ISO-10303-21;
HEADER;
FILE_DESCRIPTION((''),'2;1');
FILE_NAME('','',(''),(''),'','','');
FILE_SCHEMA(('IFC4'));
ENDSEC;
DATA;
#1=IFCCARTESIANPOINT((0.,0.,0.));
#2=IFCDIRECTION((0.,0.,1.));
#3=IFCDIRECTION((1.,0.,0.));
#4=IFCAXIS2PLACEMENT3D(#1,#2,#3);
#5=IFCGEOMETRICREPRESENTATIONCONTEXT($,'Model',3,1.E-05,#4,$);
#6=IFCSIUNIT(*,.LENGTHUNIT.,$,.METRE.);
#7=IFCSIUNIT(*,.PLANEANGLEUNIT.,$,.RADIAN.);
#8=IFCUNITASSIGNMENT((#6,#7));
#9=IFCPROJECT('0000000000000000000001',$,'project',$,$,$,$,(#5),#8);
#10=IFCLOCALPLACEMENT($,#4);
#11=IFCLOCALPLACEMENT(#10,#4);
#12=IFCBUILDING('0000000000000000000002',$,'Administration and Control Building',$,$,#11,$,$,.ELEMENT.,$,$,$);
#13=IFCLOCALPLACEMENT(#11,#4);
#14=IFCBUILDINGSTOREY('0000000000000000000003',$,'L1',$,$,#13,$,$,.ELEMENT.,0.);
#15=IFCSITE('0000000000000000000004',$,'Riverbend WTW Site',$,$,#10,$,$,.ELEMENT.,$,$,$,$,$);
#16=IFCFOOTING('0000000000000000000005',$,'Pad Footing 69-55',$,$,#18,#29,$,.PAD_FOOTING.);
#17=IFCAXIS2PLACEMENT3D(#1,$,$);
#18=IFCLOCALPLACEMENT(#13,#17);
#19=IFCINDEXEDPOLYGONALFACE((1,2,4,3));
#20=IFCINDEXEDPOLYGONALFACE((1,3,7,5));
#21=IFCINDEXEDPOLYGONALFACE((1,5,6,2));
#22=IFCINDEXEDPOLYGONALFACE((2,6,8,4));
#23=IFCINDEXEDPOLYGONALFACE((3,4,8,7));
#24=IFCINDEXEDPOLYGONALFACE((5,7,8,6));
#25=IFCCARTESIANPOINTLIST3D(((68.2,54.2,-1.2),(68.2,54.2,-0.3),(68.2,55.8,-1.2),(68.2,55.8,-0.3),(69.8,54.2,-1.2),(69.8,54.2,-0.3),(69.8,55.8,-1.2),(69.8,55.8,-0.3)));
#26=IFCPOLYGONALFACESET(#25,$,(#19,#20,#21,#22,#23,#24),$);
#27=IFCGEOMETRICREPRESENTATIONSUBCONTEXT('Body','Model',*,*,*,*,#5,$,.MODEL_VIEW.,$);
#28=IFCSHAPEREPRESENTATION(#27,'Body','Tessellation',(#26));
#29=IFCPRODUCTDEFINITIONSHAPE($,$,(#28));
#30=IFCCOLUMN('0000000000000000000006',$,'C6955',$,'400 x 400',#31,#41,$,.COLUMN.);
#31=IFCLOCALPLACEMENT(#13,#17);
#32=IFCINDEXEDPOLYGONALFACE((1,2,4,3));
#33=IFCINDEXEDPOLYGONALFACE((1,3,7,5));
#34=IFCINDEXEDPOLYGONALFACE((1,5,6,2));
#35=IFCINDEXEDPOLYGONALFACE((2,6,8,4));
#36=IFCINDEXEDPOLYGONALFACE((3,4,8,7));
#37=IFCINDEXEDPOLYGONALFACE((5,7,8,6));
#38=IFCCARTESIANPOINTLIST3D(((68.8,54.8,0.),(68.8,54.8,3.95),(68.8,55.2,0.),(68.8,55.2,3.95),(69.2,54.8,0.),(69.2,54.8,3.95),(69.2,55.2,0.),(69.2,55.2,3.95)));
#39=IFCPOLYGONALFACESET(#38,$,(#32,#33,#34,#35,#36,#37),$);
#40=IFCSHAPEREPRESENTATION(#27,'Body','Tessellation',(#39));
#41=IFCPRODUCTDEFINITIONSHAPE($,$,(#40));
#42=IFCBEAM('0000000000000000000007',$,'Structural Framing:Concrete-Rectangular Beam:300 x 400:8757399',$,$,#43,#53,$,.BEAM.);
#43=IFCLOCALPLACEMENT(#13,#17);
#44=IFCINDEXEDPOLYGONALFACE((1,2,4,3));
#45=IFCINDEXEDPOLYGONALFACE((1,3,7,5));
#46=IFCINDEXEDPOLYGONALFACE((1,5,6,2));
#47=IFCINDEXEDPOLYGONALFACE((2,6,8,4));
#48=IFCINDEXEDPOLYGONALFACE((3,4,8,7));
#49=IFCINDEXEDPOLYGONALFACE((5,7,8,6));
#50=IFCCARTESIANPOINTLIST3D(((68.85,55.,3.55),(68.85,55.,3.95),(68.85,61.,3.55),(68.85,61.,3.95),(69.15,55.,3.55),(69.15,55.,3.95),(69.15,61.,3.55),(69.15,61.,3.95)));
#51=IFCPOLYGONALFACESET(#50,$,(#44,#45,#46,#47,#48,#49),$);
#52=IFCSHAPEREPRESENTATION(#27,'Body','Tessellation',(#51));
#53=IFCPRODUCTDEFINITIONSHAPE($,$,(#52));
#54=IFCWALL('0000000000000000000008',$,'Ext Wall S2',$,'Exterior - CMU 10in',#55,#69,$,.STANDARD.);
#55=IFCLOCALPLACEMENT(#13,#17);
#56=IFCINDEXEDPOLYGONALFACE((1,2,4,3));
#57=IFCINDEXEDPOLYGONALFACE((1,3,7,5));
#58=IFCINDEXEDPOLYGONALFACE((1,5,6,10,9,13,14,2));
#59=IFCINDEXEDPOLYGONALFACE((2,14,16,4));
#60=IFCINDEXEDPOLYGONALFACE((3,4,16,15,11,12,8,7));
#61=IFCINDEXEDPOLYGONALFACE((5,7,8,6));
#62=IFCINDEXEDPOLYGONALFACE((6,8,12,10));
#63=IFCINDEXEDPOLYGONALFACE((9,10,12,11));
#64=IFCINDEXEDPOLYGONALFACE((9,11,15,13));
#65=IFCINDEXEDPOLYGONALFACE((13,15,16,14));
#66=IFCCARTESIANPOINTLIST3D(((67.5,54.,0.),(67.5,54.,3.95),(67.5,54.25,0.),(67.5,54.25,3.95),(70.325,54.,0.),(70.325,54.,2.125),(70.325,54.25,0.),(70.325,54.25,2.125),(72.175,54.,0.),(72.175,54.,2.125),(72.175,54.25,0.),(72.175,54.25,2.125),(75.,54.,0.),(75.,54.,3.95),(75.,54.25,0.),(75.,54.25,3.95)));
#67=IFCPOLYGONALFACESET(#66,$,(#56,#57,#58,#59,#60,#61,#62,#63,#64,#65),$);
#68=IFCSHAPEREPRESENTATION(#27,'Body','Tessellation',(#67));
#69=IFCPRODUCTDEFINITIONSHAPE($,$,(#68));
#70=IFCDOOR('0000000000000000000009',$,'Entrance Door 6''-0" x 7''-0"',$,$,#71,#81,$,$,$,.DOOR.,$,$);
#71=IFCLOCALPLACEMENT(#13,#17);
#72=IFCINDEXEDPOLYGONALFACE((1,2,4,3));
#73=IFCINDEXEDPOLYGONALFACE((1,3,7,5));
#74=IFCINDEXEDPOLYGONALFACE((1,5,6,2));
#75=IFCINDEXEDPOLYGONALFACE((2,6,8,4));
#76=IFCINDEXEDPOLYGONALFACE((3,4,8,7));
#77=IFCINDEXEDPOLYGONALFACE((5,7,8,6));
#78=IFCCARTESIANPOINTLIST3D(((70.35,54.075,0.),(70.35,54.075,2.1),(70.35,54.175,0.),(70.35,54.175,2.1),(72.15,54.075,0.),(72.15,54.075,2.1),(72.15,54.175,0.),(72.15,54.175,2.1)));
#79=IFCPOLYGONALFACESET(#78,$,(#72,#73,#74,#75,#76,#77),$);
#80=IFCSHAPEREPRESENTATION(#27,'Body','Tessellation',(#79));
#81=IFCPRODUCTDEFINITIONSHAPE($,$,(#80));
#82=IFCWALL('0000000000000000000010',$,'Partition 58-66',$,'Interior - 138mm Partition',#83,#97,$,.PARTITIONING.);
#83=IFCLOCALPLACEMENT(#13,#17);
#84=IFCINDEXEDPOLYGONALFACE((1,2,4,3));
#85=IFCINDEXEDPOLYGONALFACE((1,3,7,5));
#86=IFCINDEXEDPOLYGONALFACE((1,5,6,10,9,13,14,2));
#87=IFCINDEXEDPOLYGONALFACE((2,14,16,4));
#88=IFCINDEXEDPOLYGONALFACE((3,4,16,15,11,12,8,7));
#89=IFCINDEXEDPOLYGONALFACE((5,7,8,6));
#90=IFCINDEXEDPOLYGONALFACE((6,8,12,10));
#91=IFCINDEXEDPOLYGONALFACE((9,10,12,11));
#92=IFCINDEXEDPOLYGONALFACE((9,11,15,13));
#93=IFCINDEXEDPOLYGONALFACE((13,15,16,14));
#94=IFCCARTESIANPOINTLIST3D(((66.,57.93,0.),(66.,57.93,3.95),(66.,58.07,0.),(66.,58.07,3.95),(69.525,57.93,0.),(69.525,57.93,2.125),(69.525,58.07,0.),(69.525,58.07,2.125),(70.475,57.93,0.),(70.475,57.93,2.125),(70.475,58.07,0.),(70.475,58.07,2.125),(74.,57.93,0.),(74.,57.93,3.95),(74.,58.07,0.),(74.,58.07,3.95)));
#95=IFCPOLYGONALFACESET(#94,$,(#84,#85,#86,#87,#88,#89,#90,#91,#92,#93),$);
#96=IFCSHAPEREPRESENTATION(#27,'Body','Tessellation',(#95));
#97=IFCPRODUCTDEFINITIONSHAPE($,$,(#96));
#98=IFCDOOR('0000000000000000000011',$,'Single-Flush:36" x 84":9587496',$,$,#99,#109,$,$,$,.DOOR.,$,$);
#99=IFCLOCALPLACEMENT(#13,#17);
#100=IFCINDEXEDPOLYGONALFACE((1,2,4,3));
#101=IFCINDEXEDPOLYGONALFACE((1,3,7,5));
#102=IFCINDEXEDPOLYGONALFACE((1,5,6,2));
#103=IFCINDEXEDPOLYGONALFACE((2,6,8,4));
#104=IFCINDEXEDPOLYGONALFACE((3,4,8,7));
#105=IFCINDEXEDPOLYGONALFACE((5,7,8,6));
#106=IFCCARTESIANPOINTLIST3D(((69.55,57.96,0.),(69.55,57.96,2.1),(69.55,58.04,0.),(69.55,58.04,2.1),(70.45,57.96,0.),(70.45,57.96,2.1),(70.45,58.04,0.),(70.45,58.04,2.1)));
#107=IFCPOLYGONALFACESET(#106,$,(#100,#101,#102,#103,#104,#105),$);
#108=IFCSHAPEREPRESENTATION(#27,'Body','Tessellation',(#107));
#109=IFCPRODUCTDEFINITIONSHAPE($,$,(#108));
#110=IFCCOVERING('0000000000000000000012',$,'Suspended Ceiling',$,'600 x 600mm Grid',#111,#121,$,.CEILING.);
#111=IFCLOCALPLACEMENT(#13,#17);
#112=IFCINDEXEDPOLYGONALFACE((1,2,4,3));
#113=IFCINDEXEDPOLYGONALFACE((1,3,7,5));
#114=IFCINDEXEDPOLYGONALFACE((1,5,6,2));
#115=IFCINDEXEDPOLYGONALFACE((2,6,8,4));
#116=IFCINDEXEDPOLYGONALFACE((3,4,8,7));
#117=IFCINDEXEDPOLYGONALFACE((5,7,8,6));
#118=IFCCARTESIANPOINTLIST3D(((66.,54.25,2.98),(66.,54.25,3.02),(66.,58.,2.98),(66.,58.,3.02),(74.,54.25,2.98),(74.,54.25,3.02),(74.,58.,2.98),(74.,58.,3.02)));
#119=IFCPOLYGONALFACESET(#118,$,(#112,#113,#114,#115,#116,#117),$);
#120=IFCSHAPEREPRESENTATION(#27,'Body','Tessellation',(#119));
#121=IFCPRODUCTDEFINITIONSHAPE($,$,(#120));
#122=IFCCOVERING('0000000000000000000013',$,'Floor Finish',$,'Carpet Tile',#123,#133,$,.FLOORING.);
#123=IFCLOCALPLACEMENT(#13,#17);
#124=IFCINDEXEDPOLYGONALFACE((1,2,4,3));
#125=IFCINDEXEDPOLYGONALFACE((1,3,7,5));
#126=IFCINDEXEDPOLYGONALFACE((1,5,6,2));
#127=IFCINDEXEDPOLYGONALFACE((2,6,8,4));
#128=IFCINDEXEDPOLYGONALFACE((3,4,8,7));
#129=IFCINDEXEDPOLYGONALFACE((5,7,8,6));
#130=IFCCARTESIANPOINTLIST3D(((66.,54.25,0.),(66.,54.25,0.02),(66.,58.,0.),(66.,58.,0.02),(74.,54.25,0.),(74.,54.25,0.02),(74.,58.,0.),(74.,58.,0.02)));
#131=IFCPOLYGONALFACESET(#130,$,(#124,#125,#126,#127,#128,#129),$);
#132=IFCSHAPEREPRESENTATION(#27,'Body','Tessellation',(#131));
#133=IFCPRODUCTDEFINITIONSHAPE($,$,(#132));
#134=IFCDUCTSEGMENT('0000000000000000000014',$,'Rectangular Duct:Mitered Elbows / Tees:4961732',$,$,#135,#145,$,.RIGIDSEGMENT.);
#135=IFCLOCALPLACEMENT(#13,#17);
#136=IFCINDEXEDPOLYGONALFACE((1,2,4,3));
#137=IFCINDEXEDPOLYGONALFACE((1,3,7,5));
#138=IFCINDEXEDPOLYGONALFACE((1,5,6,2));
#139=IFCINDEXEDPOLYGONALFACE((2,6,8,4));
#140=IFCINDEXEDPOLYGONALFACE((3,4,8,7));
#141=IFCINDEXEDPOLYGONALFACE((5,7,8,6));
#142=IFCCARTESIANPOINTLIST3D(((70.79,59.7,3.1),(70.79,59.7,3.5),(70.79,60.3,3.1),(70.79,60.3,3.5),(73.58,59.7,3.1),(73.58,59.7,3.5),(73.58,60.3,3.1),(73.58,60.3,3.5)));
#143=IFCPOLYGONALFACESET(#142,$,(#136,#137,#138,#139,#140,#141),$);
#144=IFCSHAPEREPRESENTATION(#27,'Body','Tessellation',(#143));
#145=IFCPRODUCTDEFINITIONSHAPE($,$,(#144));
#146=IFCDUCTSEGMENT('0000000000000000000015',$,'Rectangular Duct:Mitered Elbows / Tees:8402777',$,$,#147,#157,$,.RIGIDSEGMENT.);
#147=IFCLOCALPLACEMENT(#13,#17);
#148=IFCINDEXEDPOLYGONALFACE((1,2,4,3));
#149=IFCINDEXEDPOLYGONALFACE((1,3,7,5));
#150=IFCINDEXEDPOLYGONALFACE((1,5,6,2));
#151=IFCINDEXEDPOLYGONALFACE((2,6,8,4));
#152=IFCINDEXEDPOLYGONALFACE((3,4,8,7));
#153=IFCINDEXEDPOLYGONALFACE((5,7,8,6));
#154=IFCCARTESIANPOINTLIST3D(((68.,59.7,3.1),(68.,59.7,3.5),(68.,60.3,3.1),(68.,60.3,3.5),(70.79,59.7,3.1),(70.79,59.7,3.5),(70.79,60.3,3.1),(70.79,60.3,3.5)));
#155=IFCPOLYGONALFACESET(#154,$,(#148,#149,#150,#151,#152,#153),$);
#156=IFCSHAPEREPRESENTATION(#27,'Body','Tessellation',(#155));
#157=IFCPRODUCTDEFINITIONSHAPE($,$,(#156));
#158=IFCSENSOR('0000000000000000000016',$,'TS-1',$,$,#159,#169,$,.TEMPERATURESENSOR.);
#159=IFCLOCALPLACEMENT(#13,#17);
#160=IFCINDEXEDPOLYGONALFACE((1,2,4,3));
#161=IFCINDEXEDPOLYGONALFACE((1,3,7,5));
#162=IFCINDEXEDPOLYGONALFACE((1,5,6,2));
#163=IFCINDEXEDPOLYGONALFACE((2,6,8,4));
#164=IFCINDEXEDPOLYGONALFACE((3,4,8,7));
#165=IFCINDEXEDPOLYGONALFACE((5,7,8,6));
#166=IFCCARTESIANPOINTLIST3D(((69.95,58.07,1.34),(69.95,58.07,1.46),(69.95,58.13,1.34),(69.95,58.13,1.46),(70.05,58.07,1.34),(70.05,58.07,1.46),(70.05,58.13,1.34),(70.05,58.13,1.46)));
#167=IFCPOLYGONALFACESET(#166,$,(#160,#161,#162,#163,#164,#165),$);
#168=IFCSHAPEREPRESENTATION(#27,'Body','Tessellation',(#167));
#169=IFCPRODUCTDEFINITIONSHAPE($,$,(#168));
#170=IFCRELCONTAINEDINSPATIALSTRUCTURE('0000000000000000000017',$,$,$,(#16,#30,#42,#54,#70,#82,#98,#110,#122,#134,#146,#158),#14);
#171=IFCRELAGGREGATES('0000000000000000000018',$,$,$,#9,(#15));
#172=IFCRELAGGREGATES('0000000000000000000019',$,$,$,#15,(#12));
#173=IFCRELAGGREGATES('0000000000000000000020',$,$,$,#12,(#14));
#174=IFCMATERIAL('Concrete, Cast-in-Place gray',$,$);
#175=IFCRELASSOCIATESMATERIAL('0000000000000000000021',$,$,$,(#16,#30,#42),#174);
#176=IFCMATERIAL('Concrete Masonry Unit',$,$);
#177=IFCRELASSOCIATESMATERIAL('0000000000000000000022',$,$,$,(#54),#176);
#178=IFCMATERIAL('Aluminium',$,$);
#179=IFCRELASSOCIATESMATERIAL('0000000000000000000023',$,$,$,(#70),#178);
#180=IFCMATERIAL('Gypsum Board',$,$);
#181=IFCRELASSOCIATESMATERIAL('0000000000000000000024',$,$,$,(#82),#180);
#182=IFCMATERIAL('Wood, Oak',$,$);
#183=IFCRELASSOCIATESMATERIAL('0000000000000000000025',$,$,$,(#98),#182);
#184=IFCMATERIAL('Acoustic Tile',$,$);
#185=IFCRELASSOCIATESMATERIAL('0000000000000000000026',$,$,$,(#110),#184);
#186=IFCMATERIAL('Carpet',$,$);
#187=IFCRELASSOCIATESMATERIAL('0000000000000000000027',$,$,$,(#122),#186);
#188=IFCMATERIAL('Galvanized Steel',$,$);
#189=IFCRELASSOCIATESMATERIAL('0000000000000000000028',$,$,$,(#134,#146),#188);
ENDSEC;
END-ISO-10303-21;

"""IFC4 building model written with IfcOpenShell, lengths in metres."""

from ifc_helpers import new_model, si_unit, frame, origin_with_axes, origin_2d, place, context, subcontext, project, spatial, rectangle, extrude, material, element, fill, save


model = new_model("IFC4")

# Units and contexts
model_context = context("Model", 3, precision=1e-05, world=origin_with_axes())
body_context = subcontext(model_context, "Body", "Model", "MODEL_VIEW")
ifc_project = project(units=[si_unit("LENGTHUNIT", "METRE"), si_unit("PLANEANGLEUNIT", "RADIAN")], contexts=[model_context])

# Site, building, storey
site_placement = place(None, origin_with_axes())
site = spatial("IfcSite", under=ifc_project, at=site_placement, Name="Riverbend WTW Site", CompositionType="ELEMENT")
building_placement = place(site_placement, origin_with_axes())
building = spatial("IfcBuilding", under=site, at=building_placement, Name="Administration and Control Building", CompositionType="ELEMENT")
storey_placement = place(building_placement, origin_with_axes())
storey = spatial("IfcBuildingStorey", under=building, at=storey_placement, Name="L1", CompositionType="ELEMENT", Elevation=0.0)

# Footing
ifc_material_1 = material(Name="Concrete, Cast-in-Place gray")
footing_placement = place(None, frame((69.0, 55.0, -0.75), z_axis=(0.0, 0.0, 1.0), x_axis=(1.0, 0.0, 0.0)))
element("IfcFooting", 1, at=footing_placement, inside=storey, material=ifc_material_1, Name="Pad Footing 69-55", PredefinedType="PAD_FOOTING", context=body_context, shape_type="SweptSolid", body=[
    extrude(rectangle(XDim=1.6, YDim=1.6, at=origin_2d()), frame((0.0, 0.0, -0.45), z_axis=(0.0, 0.0, 1.0), x_axis=(1.0, 0.0, 0.0)), (0.0, 0.0, 1.0), 0.9),
])

# Column
column_placement = place(None, frame((69.0, 55.0, 1.975), z_axis=(0.0, 0.0, 1.0), x_axis=(1.0, 0.0, 0.0)))
element("IfcColumn", 2, at=column_placement, inside=storey, material=ifc_material_1, Name="C6955", ObjectType="400 x 400", PredefinedType="COLUMN", context=body_context, shape_type="SweptSolid", body=[
    extrude(rectangle(XDim=0.4, YDim=0.4, at=origin_2d()), frame((0.0, 0.0, -1.975), z_axis=(0.0, 0.0, 1.0), x_axis=(1.0, 0.0, 0.0)), (0.0, 0.0, 1.0), 3.95),
])

# Beam
beam_placement = place(None, frame((69.0, 58.0, 3.75), z_axis=(0.0, 0.0, 1.0), x_axis=(1.0, 0.0, 0.0)))
element("IfcBeam", 3, at=beam_placement, inside=storey, material=ifc_material_1, Name="Structural Framing:Concrete-Rectangular Beam:300 x 400:8757399", PredefinedType="BEAM", context=body_context, shape_type="SweptSolid", body=[
    extrude(rectangle(XDim=0.3, YDim=6.0, at=origin_2d()), frame((0.0, 0.0, -0.2), z_axis=(0.0, 0.0, 1.0), x_axis=(1.0, 0.0, 0.0)), (0.0, 0.0, 1.0), 0.4),
])

# Walls, openings, doors
ifc_material_2 = material(Name="Concrete Masonry Unit")
wall_1_placement = place(None, frame((71.25, 54.125, 1.975), z_axis=(0.0, 0.0, 1.0), x_axis=(1.0, 0.0, 0.0)))
wall_1 = element("IfcWall", 4, at=wall_1_placement, inside=storey, material=ifc_material_2, Name="Ext Wall S2", ObjectType="Exterior - CMU 10in", PredefinedType="STANDARD", context=body_context, shape_type="SweptSolid", body=[
    extrude(rectangle(XDim=7.5, YDim=0.25, at=origin_2d()), frame((0.0, 0.0, -1.975), z_axis=(0.0, 0.0, 1.0), x_axis=(1.0, 0.0, 0.0)), (0.0, 0.0, 1.0), 3.95),
])
opening_1_placement = place(None, frame((71.25, 54.125, 1.05), z_axis=(0.0, 0.0, 1.0), x_axis=(1.0, 0.0, 0.0)))
opening_1 = element("IfcOpeningElement", 5, at=opening_1_placement, inside=storey, cuts=wall_1, context=body_context, shape_type="SweptSolid", body=[
    extrude(rectangle(XDim=1.85, YDim=0.4, at=origin_2d()), frame((0.0, 0.0, -1.075), z_axis=(0.0, 0.0, 1.0), x_axis=(1.0, 0.0, 0.0)), (0.0, 0.0, 1.0), 2.15),
])
ifc_material_3 = material(Name="Aluminium")
door_1_placement = place(None, frame((71.25, 54.125, 1.05), z_axis=(0.0, 0.0, 1.0), x_axis=(1.0, 0.0, 0.0)))
door_1 = element("IfcDoor", 6, at=door_1_placement, inside=storey, material=ifc_material_3, Name="Entrance Door 6'-0\" x 7'-0\"", PredefinedType="DOOR", context=body_context, shape_type="SweptSolid", body=[
    extrude(rectangle(XDim=1.8, YDim=0.1, at=origin_2d()), frame((0.0, 0.0, -1.05), z_axis=(0.0, 0.0, 1.0), x_axis=(1.0, 0.0, 0.0)), (0.0, 0.0, 1.0), 2.1),
])
fill(opening_1, door_1)
ifc_material_4 = material(Name="Gypsum Board")
wall_2_placement = place(None, frame((70.0, 58.0, 1.975), z_axis=(0.0, 0.0, 1.0), x_axis=(1.0, 0.0, 0.0)))
wall_2 = element("IfcWall", 7, at=wall_2_placement, inside=storey, material=ifc_material_4, Name="Partition 58-66", ObjectType="Interior - 138mm Partition", PredefinedType="PARTITIONING", context=body_context, shape_type="SweptSolid", body=[
    extrude(rectangle(XDim=8.0, YDim=0.14, at=origin_2d()), frame((0.0, 0.0, -1.975), z_axis=(0.0, 0.0, 1.0), x_axis=(1.0, 0.0, 0.0)), (0.0, 0.0, 1.0), 3.95),
])
opening_2_placement = place(None, frame((70.0, 58.0, 1.05), z_axis=(0.0, 0.0, 1.0), x_axis=(1.0, 0.0, 0.0)))
opening_2 = element("IfcOpeningElement", 8, at=opening_2_placement, inside=storey, cuts=wall_2, context=body_context, shape_type="SweptSolid", body=[
    extrude(rectangle(XDim=0.95, YDim=0.4, at=origin_2d()), frame((0.0, 0.0, -1.075), z_axis=(0.0, 0.0, 1.0), x_axis=(1.0, 0.0, 0.0)), (0.0, 0.0, 1.0), 2.15),
])
ifc_material_5 = material(Name="Wood, Oak")
door_2_placement = place(None, frame((70.0, 58.0, 1.05), z_axis=(0.0, 0.0, 1.0), x_axis=(1.0, 0.0, 0.0)))
door_2 = element("IfcDoor", 9, at=door_2_placement, inside=storey, material=ifc_material_5, Name="Single-Flush:36\" x 84\":9587496", PredefinedType="DOOR", context=body_context, shape_type="SweptSolid", body=[
    extrude(rectangle(XDim=0.9, YDim=0.08, at=origin_2d()), frame((0.0, 0.0, -1.05), z_axis=(0.0, 0.0, 1.0), x_axis=(1.0, 0.0, 0.0)), (0.0, 0.0, 1.0), 2.1),
])
fill(opening_2, door_2)

# Coverings
ifc_material_6 = material(Name="Acoustic Tile")
covering_1_placement = place(None, frame((70.0, 56.125, 3.0), z_axis=(0.0, 0.0, 1.0), x_axis=(1.0, 0.0, 0.0)))
element("IfcCovering", 10, at=covering_1_placement, inside=storey, material=ifc_material_6, Name="Suspended Ceiling", ObjectType="600 x 600mm Grid", PredefinedType="CEILING", context=body_context, shape_type="SweptSolid", body=[
    extrude(rectangle(XDim=8.0, YDim=3.75, at=origin_2d()), frame((0.0, 0.0, -0.02), z_axis=(0.0, 0.0, 1.0), x_axis=(1.0, 0.0, 0.0)), (0.0, 0.0, 1.0), 0.04),
])
ifc_material_7 = material(Name="Carpet")
covering_2_placement = place(None, frame((70.0, 56.125, 0.01), z_axis=(0.0, 0.0, 1.0), x_axis=(1.0, 0.0, 0.0)))
element("IfcCovering", 11, at=covering_2_placement, inside=storey, material=ifc_material_7, Name="Floor Finish", ObjectType="Carpet Tile", PredefinedType="FLOORING", context=body_context, shape_type="SweptSolid", body=[
    extrude(rectangle(XDim=8.0, YDim=3.75, at=origin_2d()), frame((0.0, 0.0, -0.01), z_axis=(0.0, 0.0, 1.0), x_axis=(1.0, 0.0, 0.0)), (0.0, 0.0, 1.0), 0.02),
])

# Duct segments
ifc_material_8 = material(Name="Galvanized Steel")
duct_segment_1_placement = place(None, frame((72.185, 60.0, 3.3), z_axis=(0.0, 0.0, 1.0), x_axis=(1.0, 0.0, 0.0)))
element("IfcDuctSegment", 12, at=duct_segment_1_placement, inside=storey, material=ifc_material_8, Name="Rectangular Duct:Mitered Elbows / Tees:4961732", PredefinedType="RIGIDSEGMENT", context=body_context, shape_type="SweptSolid", body=[
    extrude(rectangle(XDim=2.79, YDim=0.6, at=origin_2d()), frame((0.0, 0.0, -0.2), z_axis=(0.0, 0.0, 1.0), x_axis=(1.0, 0.0, 0.0)), (0.0, 0.0, 1.0), 0.4),
])
duct_segment_2_placement = place(None, frame((69.395, 60.0, 3.3), z_axis=(0.0, 0.0, 1.0), x_axis=(1.0, 0.0, 0.0)))
element("IfcDuctSegment", 13, at=duct_segment_2_placement, inside=storey, material=ifc_material_8, Name="Rectangular Duct:Mitered Elbows / Tees:8402777", PredefinedType="RIGIDSEGMENT", context=body_context, shape_type="SweptSolid", body=[
    extrude(rectangle(XDim=2.79, YDim=0.6, at=origin_2d()), frame((0.0, 0.0, -0.2), z_axis=(0.0, 0.0, 1.0), x_axis=(1.0, 0.0, 0.0)), (0.0, 0.0, 1.0), 0.4),
])

# Sensor
sensor_placement = place(None, frame((70.0, 58.1, 1.4), z_axis=(0.0, 0.0, 1.0), x_axis=(1.0, 0.0, 0.0)))
element("IfcSensor", 14, at=sensor_placement, inside=storey, Name="TS-1", PredefinedType="TEMPERATURESENSOR", context=body_context, shape_type="SweptSolid", body=[
    extrude(rectangle(XDim=0.1, YDim=0.06, at=origin_2d()), frame((0.0, 0.0, -0.06), z_axis=(0.0, 0.0, 1.0), x_axis=(1.0, 0.0, 0.0)), (0.0, 0.0, 1.0), 0.12),
])

save(model, "model.ifc")
